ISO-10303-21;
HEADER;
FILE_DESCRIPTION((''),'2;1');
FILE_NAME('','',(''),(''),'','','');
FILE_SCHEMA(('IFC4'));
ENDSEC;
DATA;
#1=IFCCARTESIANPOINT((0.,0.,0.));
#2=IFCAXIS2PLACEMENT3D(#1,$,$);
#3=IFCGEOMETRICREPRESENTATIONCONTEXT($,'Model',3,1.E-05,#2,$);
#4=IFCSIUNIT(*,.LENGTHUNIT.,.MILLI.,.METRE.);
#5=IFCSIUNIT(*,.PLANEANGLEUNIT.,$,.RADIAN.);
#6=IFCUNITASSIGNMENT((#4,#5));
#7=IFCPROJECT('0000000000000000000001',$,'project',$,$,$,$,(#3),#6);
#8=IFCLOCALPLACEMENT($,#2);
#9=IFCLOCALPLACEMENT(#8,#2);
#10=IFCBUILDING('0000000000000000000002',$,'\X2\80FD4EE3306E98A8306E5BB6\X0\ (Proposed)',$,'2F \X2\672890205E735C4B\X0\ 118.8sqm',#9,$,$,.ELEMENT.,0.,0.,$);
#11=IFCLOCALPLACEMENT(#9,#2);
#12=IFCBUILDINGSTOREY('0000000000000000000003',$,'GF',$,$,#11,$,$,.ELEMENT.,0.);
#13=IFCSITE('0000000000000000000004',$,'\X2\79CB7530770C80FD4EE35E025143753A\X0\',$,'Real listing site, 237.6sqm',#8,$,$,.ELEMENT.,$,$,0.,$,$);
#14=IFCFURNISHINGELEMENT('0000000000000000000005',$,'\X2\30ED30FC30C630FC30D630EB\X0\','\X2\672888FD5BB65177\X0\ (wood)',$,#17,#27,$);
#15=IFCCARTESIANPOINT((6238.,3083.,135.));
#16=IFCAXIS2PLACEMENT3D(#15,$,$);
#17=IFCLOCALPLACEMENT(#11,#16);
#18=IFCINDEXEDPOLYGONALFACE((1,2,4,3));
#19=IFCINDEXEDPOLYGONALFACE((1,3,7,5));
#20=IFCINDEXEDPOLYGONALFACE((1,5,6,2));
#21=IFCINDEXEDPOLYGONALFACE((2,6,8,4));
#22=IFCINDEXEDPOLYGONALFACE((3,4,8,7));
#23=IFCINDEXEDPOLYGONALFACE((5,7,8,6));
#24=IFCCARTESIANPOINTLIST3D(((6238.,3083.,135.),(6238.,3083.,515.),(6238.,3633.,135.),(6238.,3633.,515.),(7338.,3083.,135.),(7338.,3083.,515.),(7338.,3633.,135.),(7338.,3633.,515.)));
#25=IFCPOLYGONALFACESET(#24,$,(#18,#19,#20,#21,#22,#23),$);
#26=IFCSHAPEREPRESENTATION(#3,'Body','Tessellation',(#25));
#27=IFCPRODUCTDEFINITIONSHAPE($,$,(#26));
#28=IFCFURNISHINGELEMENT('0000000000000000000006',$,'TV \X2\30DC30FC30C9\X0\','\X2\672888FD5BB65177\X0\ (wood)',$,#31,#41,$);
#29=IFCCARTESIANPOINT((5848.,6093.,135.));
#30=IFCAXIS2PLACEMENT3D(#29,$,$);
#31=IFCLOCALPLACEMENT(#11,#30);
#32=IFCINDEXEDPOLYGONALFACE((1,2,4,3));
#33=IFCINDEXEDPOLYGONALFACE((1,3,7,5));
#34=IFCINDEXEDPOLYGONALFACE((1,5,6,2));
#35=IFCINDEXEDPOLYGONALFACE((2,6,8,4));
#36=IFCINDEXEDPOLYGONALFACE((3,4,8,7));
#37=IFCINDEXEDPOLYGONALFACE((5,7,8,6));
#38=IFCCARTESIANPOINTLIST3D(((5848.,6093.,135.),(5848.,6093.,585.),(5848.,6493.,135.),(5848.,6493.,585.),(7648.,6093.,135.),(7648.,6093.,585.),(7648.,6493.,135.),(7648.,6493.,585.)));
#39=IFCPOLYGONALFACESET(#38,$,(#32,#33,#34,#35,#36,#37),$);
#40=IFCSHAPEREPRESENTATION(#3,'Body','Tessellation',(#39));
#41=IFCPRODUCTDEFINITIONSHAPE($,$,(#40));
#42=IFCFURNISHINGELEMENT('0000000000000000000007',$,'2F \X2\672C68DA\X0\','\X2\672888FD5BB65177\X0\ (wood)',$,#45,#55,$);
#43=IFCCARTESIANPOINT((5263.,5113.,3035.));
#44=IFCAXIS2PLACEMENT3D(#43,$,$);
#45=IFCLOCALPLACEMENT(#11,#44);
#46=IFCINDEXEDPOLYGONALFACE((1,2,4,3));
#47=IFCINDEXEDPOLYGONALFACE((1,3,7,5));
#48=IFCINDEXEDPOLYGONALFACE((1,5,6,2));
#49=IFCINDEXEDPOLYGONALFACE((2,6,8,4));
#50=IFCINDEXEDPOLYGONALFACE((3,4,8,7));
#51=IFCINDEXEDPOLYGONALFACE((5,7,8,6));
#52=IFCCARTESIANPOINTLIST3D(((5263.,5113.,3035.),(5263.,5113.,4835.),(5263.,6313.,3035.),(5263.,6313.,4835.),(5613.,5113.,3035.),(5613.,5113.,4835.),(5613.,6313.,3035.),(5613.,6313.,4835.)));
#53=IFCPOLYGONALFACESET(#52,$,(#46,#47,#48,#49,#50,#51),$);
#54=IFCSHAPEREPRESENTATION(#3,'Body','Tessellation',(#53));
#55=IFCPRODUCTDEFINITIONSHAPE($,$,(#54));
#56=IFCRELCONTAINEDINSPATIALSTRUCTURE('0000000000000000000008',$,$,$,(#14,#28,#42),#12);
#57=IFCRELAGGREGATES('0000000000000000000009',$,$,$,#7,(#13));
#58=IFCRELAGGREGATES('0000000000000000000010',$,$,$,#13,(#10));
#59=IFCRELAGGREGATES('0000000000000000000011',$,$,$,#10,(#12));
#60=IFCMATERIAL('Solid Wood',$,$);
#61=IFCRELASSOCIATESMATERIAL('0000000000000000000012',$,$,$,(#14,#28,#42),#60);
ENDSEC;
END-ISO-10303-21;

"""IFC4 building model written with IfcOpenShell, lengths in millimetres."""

from ifc_helpers import new_model, si_unit, frame, frame_2d, origin, place, context, project, spatial, rectangle, extrude, material, element, save


model = new_model("IFC4")

# Units and contexts
model_context = context("Model", 3, precision=1e-05, world=origin())
ifc_project = project(units=[si_unit("LENGTHUNIT", "METRE", prefix="MILLI"), si_unit("PLANEANGLEUNIT", "RADIAN")], contexts=[model_context])

# Site, building, storey
site_placement = place(None, origin())
site = spatial("IfcSite", under=ifc_project, at=site_placement, Name="秋田県能代市元町", ObjectType="Real listing site, 237.6sqm", CompositionType="ELEMENT", RefElevation=0.0)
building_placement = place(site_placement, origin())
building = spatial("IfcBuilding", under=site, at=building_placement, Name="能代の風の家 (Proposed)", ObjectType="2F 木造平屋 118.8sqm", CompositionType="ELEMENT", ElevationOfRefHeight=0.0, ElevationOfTerrain=0.0)
storey_placement = place(building_placement, origin())
storey = spatial("IfcBuildingStorey", under=building, at=storey_placement, Name="GF", CompositionType="ELEMENT", Elevation=0.0)

# Shared definitions
ifc_material_1 = material(Name="Solid Wood")

# Furnishing elements
furnishing_1_placement = place(storey_placement, frame((6238.0, 3083.0, 135.0)))
element("IfcFurnishingElement", 1, at=furnishing_1_placement, inside=storey, material=ifc_material_1, Name="ローテーブル", Description="木製家具 (wood)", context=model_context, shape_type="SweptSolid", body=[
    extrude(rectangle(XDim=1100.0, YDim=550.0, at=frame_2d((550.0, 275.0))), frame((6238.0, 3083.0, 135.0)), (0.0, 0.0, 1.0), 380.0),
])
furnishing_2_placement = place(storey_placement, frame((5848.0, 6093.0, 135.0)))
element("IfcFurnishingElement", 2, at=furnishing_2_placement, inside=storey, material=ifc_material_1, Name="TV ボード", Description="木製家具 (wood)", context=model_context, shape_type="SweptSolid", body=[
    extrude(rectangle(XDim=1800.0, YDim=400.0, at=frame_2d((900.0, 200.0))), frame((5848.0, 6093.0, 135.0)), (0.0, 0.0, 1.0), 450.0),
])
furnishing_3_placement = place(storey_placement, frame((5263.0, 5113.0, 3035.0)))
element("IfcFurnishingElement", 3, at=furnishing_3_placement, inside=storey, material=ifc_material_1, Name="2F 本棚", Description="木製家具 (wood)", context=model_context, shape_type="SweptSolid", body=[
    extrude(rectangle(XDim=350.0, YDim=1200.0, at=frame_2d((175.0, 600.0))), frame((5263.0, 5113.0, 3035.0)), (0.0, 0.0, 1.0), 1800.0),
])

save(model, "model.ifc")
